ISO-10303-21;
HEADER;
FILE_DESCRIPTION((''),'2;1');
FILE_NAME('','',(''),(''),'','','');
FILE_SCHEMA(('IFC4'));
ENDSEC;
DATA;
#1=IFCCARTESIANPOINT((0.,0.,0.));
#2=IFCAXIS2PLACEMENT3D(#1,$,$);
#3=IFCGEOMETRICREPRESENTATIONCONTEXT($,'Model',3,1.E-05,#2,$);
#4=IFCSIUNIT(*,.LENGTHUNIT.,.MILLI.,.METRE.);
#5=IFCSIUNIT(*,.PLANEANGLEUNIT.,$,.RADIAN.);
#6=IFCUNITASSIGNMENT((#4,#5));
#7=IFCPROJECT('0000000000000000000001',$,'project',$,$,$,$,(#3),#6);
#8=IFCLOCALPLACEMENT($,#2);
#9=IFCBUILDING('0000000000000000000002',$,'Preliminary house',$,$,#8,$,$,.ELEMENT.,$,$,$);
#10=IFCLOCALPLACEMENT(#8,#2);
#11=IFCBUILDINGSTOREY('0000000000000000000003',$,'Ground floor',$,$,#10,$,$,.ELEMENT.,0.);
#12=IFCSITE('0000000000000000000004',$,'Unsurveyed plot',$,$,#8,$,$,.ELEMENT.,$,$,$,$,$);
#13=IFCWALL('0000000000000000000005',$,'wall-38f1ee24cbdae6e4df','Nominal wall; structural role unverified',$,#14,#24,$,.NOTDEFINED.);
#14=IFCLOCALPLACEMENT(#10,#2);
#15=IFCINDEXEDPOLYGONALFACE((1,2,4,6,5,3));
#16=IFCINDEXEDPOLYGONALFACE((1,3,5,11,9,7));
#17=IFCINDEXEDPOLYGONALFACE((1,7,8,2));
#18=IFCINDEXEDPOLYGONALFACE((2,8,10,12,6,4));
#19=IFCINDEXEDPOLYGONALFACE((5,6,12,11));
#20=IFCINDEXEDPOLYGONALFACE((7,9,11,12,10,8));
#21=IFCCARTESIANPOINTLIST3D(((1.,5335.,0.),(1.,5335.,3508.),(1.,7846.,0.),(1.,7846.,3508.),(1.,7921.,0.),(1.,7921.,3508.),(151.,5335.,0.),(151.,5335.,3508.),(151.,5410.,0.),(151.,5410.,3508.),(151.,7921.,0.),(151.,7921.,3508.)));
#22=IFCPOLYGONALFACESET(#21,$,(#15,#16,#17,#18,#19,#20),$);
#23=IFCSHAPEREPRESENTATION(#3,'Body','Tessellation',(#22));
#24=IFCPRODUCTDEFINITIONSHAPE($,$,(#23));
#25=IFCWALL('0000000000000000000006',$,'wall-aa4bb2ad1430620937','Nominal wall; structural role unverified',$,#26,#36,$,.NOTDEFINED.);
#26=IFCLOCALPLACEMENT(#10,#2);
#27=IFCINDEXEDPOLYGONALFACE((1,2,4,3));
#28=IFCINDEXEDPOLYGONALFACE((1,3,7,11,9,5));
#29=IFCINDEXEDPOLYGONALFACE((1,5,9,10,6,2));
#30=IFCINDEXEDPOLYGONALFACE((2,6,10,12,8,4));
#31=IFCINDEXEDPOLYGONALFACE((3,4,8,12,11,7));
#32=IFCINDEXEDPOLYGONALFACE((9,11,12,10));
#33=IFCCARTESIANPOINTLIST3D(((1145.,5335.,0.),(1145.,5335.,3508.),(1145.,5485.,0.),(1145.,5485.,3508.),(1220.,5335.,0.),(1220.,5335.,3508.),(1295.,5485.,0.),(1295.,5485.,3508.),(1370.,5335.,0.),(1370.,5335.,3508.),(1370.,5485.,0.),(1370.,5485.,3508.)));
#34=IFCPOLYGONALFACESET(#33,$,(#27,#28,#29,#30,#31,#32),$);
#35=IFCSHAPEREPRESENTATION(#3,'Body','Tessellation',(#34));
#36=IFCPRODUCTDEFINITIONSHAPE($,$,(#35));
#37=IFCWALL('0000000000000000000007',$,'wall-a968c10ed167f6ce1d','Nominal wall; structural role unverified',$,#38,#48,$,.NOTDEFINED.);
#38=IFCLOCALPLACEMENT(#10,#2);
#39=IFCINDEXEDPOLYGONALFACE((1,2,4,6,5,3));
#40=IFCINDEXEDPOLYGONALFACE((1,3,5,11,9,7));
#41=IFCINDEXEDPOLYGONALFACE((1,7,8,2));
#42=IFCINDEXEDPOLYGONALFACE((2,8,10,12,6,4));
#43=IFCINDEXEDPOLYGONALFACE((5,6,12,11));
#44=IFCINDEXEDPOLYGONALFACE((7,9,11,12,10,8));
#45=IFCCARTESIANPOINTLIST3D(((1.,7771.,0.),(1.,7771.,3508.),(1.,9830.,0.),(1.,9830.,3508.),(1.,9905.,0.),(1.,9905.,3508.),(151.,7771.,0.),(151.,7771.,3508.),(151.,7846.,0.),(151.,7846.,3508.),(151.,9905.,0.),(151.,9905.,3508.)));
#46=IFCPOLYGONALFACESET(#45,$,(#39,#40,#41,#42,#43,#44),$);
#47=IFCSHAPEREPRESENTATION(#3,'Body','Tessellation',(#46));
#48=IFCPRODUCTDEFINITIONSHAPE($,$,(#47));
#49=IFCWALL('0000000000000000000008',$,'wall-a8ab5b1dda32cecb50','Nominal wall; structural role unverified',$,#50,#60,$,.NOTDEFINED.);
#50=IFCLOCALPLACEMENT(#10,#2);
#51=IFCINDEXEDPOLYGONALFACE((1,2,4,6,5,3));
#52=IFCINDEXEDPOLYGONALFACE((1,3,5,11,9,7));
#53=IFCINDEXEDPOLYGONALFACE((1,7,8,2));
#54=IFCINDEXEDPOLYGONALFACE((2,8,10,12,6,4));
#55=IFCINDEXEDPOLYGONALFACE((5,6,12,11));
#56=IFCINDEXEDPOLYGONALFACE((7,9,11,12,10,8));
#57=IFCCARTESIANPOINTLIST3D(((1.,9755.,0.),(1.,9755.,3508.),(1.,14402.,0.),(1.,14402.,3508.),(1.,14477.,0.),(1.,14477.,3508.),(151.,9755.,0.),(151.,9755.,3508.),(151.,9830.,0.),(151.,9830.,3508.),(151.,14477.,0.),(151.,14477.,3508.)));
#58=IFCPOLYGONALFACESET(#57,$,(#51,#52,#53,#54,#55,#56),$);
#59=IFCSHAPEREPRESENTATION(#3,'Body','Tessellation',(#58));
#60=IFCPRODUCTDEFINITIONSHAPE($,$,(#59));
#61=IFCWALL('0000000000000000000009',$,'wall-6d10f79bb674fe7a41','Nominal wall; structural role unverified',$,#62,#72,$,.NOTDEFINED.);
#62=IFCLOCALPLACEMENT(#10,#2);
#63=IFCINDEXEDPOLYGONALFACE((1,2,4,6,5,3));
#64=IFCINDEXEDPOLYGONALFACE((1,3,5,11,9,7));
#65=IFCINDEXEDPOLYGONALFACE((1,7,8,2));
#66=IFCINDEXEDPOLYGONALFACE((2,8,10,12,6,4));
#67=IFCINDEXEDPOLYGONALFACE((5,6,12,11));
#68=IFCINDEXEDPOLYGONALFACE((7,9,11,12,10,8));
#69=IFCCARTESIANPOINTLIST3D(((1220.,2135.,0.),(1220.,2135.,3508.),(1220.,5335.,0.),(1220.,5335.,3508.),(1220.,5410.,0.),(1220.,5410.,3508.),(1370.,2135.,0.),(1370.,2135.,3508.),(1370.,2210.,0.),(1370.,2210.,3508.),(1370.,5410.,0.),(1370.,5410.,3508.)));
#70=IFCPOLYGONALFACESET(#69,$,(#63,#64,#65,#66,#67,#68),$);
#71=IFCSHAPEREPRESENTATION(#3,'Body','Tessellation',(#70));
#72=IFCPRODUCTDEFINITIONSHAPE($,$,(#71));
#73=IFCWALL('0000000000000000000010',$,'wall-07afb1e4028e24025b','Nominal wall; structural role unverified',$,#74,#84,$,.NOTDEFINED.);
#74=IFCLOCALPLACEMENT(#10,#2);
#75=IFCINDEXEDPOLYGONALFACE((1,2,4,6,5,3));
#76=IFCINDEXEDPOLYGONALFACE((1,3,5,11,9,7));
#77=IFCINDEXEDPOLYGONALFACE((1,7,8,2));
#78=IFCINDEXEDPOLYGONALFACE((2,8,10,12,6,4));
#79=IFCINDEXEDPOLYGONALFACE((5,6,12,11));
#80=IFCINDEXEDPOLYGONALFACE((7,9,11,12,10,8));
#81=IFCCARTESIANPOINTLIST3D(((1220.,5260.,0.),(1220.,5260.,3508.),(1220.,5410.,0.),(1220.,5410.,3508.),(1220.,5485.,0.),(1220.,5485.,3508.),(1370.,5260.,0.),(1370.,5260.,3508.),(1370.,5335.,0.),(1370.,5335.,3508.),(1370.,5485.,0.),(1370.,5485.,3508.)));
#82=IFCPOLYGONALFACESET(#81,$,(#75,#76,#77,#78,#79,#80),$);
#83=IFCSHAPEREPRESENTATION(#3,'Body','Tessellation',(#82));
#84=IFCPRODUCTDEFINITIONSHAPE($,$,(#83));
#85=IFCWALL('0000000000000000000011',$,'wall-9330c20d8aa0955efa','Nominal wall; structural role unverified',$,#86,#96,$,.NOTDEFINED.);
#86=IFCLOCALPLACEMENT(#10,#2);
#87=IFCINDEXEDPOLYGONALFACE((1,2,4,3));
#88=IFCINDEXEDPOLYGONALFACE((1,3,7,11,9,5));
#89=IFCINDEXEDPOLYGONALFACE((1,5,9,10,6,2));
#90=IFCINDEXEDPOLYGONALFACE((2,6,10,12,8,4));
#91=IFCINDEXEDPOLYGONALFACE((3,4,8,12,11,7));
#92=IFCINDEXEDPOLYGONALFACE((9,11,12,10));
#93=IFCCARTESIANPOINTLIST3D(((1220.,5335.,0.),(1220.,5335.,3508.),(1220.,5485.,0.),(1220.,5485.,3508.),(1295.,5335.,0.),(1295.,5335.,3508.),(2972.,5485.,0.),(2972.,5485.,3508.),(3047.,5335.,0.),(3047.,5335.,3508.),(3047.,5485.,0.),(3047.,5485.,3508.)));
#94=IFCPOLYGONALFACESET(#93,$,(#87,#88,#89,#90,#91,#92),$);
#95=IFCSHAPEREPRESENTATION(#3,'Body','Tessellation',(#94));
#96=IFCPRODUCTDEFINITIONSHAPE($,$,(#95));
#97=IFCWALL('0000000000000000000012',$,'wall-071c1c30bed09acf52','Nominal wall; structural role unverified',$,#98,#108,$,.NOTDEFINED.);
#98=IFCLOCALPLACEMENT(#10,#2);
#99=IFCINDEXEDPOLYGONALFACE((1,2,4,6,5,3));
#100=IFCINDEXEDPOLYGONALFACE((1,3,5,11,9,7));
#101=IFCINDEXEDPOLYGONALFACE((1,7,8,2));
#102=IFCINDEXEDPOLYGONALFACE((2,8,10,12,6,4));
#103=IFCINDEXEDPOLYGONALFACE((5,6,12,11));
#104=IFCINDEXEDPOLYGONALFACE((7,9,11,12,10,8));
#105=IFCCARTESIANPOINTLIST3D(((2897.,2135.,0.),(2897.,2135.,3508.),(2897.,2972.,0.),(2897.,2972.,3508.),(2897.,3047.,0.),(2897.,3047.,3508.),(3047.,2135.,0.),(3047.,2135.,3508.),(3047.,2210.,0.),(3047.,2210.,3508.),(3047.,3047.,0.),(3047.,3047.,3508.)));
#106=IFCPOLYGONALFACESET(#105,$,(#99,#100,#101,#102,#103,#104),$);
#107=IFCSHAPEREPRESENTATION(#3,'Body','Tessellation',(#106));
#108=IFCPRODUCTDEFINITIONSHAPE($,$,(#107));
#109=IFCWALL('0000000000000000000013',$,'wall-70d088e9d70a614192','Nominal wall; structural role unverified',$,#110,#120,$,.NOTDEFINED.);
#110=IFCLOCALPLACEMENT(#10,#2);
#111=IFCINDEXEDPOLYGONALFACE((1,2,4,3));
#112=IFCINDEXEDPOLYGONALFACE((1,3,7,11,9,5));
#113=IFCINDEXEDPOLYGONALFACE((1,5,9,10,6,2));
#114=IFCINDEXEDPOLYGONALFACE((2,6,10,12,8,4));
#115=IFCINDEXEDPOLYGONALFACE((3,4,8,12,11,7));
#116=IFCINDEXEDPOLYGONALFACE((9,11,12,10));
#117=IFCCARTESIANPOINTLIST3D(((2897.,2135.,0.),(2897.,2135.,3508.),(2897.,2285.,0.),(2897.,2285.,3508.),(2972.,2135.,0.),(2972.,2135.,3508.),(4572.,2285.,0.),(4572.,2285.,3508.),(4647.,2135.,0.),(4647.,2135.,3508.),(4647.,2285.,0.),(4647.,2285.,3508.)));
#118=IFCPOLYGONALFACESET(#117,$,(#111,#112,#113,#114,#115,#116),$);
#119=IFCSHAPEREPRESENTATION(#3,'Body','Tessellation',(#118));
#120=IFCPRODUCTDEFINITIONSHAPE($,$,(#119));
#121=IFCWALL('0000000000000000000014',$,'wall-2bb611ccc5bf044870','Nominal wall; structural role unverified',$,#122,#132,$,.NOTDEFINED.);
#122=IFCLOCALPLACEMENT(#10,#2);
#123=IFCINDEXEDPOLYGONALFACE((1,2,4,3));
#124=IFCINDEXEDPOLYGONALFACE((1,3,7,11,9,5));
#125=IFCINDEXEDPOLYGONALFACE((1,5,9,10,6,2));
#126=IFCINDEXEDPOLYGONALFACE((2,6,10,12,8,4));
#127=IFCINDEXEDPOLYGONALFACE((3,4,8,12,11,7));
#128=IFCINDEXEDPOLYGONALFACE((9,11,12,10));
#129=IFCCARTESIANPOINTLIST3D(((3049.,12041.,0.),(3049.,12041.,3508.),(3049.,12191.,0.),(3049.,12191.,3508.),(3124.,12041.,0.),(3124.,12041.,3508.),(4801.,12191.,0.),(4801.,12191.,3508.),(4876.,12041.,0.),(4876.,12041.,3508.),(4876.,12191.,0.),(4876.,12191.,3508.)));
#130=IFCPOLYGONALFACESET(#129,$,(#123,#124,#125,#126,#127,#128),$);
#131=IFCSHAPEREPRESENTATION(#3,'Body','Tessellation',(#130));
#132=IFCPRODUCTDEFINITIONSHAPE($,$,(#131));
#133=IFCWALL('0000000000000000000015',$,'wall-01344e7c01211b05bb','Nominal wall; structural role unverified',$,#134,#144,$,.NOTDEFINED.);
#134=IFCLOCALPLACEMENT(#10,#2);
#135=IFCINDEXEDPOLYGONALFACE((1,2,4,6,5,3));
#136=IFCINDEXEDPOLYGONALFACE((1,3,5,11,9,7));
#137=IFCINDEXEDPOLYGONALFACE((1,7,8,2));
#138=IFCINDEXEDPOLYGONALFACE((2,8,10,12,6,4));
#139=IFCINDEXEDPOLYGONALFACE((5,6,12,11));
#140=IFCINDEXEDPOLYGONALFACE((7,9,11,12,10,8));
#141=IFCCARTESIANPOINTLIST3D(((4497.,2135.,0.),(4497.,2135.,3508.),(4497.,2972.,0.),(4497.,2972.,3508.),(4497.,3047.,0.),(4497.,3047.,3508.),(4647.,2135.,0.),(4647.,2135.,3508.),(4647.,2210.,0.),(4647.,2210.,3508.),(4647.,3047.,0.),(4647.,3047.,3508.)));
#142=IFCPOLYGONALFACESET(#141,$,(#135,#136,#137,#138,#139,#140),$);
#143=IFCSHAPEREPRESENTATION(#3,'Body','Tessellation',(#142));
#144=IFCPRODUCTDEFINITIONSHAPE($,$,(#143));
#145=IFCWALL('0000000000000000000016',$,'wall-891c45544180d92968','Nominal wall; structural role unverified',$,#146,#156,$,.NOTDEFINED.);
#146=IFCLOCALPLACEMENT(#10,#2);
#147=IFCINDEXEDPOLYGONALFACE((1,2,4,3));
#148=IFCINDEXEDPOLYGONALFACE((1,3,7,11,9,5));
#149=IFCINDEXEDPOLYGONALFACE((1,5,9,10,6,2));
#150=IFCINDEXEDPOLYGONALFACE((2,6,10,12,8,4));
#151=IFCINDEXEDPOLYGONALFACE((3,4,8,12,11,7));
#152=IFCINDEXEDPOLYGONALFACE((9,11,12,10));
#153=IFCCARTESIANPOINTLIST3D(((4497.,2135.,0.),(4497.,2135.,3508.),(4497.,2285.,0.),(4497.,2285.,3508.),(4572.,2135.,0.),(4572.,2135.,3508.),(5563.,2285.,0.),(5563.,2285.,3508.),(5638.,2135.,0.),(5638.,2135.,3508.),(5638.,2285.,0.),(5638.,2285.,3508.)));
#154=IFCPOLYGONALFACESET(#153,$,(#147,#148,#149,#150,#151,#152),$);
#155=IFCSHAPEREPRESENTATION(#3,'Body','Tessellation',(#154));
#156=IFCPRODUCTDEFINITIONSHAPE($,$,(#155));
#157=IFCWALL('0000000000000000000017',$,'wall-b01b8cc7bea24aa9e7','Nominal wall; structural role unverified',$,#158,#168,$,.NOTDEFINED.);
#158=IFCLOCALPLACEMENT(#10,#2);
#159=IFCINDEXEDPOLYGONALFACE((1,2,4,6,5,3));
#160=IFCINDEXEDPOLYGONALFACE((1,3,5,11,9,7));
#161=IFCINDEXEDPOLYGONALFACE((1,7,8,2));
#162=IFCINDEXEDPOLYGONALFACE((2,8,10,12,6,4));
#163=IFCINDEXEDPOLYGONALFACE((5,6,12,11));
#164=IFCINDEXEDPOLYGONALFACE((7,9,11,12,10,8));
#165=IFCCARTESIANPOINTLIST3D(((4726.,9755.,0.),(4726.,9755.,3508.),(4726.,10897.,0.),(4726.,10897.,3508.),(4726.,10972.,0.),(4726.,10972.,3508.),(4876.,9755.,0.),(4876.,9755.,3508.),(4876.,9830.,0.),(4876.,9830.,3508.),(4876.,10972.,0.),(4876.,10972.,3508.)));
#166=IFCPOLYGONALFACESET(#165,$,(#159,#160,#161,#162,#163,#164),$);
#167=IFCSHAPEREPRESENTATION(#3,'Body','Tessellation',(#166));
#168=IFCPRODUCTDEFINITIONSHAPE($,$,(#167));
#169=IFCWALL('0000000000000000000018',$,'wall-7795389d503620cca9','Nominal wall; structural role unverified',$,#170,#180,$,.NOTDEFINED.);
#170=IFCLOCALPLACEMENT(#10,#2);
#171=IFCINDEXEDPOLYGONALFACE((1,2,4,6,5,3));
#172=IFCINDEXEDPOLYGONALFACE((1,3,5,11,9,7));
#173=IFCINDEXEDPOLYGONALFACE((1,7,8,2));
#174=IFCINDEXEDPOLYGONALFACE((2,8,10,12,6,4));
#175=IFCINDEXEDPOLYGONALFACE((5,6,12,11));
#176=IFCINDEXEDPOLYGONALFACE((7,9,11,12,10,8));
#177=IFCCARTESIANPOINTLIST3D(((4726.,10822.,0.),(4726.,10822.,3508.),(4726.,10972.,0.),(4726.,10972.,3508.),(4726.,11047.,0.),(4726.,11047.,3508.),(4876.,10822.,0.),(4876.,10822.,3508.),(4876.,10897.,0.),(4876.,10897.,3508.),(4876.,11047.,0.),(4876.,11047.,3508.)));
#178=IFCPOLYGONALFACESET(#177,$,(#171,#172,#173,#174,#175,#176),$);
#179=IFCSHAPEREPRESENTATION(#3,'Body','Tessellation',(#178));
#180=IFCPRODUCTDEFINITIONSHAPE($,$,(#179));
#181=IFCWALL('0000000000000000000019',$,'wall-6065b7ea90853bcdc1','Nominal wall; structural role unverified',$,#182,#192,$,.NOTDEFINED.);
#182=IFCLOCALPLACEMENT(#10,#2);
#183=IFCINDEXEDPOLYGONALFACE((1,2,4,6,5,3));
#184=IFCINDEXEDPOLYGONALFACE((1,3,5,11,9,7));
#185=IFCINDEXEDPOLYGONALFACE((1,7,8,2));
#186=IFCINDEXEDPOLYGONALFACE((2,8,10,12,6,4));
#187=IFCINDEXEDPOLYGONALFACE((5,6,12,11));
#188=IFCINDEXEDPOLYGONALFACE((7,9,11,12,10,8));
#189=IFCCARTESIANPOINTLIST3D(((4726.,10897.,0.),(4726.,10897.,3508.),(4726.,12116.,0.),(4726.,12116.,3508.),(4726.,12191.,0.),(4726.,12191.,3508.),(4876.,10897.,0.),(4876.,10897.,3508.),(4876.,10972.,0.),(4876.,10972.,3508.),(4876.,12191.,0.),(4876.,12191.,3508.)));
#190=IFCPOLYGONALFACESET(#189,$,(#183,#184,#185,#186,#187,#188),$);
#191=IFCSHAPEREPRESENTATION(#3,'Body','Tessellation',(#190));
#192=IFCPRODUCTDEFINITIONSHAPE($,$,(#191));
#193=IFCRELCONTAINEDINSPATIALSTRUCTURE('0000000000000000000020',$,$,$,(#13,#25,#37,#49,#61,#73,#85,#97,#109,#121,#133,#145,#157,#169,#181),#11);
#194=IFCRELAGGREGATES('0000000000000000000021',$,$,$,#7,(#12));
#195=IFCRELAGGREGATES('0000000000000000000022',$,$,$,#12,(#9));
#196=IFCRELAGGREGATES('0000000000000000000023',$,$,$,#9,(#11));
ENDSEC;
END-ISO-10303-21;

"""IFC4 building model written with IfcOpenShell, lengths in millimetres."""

from ifc_helpers import new_model, si_unit, origin, place, context, project, spatial, polyline, outline, extrude, element, save


model = new_model("IFC4")

# Units and contexts
model_context = context("Model", 3, precision=1e-05, world=origin())
ifc_project = project(units=[si_unit("LENGTHUNIT", "METRE", prefix="MILLI"), si_unit("PLANEANGLEUNIT", "RADIAN")], contexts=[model_context])

# Site, building, storey
placement_1 = place(None, origin())
site = spatial("IfcSite", under=ifc_project, at=placement_1, Name="Unsurveyed plot", CompositionType="ELEMENT")
building = spatial("IfcBuilding", under=site, at=placement_1, Name="Preliminary house", CompositionType="ELEMENT")
placement_2 = place(placement_1, origin())
storey = spatial("IfcBuildingStorey", under=building, at=placement_2, Name="Ground floor", CompositionType="ELEMENT", Elevation=0.0)

# Wall
element("IfcWall", 1, at=placement_2, inside=storey, Name="wall-38f1ee24cbdae6e4df", Description="Nominal wall; structural role unverified", PredefinedType="NOTDEFINED", context=model_context, shape_type="SweptSolid", body=[
    extrude(outline(polyline([(1.0, 7846.0), (1.0, 7921.0), (151.0, 7921.0), (151.0, 5410.0), (151.0, 5335.0), (1.0, 5335.0), (1.0, 7846.0)])), origin(), (0.0, 0.0, 1.0), 3508.0),
])

# Walls
element("IfcWall", 2, at=placement_2, inside=storey, Name="wall-aa4bb2ad1430620937", Description="Nominal wall; structural role unverified", PredefinedType="NOTDEFINED", context=model_context, shape_type="SweptSolid", body=[
    extrude(outline(polyline([(1295.0, 5485.0), (1370.0, 5485.0), (1370.0, 5335.0), (1220.0, 5335.0), (1145.0, 5335.0), (1145.0, 5485.0), (1295.0, 5485.0)])), origin(), (0.0, 0.0, 1.0), 3508.0),
])
element("IfcWall", 3, at=placement_2, inside=storey, Name="wall-a968c10ed167f6ce1d", Description="Nominal wall; structural role unverified", PredefinedType="NOTDEFINED", context=model_context, shape_type="SweptSolid", body=[
    extrude(outline(polyline([(1.0, 9830.0), (1.0, 9905.0), (151.0, 9905.0), (151.0, 7846.0), (151.0, 7771.0), (1.0, 7771.0), (1.0, 9830.0)])), origin(), (0.0, 0.0, 1.0), 3508.0),
])

# Wall
element("IfcWall", 4, at=placement_2, inside=storey, Name="wall-a8ab5b1dda32cecb50", Description="Nominal wall; structural role unverified", PredefinedType="NOTDEFINED", context=model_context, shape_type="SweptSolid", body=[
    extrude(outline(polyline([(1.0, 14402.0), (1.0, 14477.0), (151.0, 14477.0), (151.0, 9830.0), (151.0, 9755.0), (1.0, 9755.0), (1.0, 14402.0)])), origin(), (0.0, 0.0, 1.0), 3508.0),
])

# Walls
element("IfcWall", 5, at=placement_2, inside=storey, Name="wall-6d10f79bb674fe7a41", Description="Nominal wall; structural role unverified", PredefinedType="NOTDEFINED", context=model_context, shape_type="SweptSolid", body=[
    extrude(outline(polyline([(1220.0, 5335.0), (1220.0, 5410.0), (1370.0, 5410.0), (1370.0, 2210.0), (1370.0, 2135.0), (1220.0, 2135.0), (1220.0, 5335.0)])), origin(), (0.0, 0.0, 1.0), 3508.0),
])
element("IfcWall", 6, at=placement_2, inside=storey, Name="wall-07afb1e4028e24025b", Description="Nominal wall; structural role unverified", PredefinedType="NOTDEFINED", context=model_context, shape_type="SweptSolid", body=[
    extrude(outline(polyline([(1220.0, 5410.0), (1220.0, 5485.0), (1370.0, 5485.0), (1370.0, 5335.0), (1370.0, 5260.0), (1220.0, 5260.0), (1220.0, 5410.0)])), origin(), (0.0, 0.0, 1.0), 3508.0),
])

# Walls
element("IfcWall", 7, at=placement_2, inside=storey, Name="wall-9330c20d8aa0955efa", Description="Nominal wall; structural role unverified", PredefinedType="NOTDEFINED", context=model_context, shape_type="SweptSolid", body=[
    extrude(outline(polyline([(2972.0, 5485.0), (3047.0, 5485.0), (3047.0, 5335.0), (1295.0, 5335.0), (1220.0, 5335.0), (1220.0, 5485.0), (2972.0, 5485.0)])), origin(), (0.0, 0.0, 1.0), 3508.0),
])
element("IfcWall", 8, at=placement_2, inside=storey, Name="wall-071c1c30bed09acf52", Description="Nominal wall; structural role unverified", PredefinedType="NOTDEFINED", context=model_context, shape_type="SweptSolid", body=[
    extrude(outline(polyline([(2897.0, 2972.0), (2897.0, 3047.0), (3047.0, 3047.0), (3047.0, 2210.0), (3047.0, 2135.0), (2897.0, 2135.0), (2897.0, 2972.0)])), origin(), (0.0, 0.0, 1.0), 3508.0),
])
element("IfcWall", 9, at=placement_2, inside=storey, Name="wall-70d088e9d70a614192", Description="Nominal wall; structural role unverified", PredefinedType="NOTDEFINED", context=model_context, shape_type="SweptSolid", body=[
    extrude(outline(polyline([(4572.0, 2285.0), (4647.0, 2285.0), (4647.0, 2135.0), (2972.0, 2135.0), (2897.0, 2135.0), (2897.0, 2285.0), (4572.0, 2285.0)])), origin(), (0.0, 0.0, 1.0), 3508.0),
])

# Wall
element("IfcWall", 10, at=placement_2, inside=storey, Name="wall-2bb611ccc5bf044870", Description="Nominal wall; structural role unverified", PredefinedType="NOTDEFINED", context=model_context, shape_type="SweptSolid", body=[
    extrude(outline(polyline([(4801.0, 12191.0), (4876.0, 12191.0), (4876.0, 12041.0), (3124.0, 12041.0), (3049.0, 12041.0), (3049.0, 12191.0), (4801.0, 12191.0)])), origin(), (0.0, 0.0, 1.0), 3508.0),
])

# Walls
element("IfcWall", 11, at=placement_2, inside=storey, Name="wall-01344e7c01211b05bb", Description="Nominal wall; structural role unverified", PredefinedType="NOTDEFINED", context=model_context, shape_type="SweptSolid", body=[
    extrude(outline(polyline([(4497.0, 2972.0), (4497.0, 3047.0), (4647.0, 3047.0), (4647.0, 2210.0), (4647.0, 2135.0), (4497.0, 2135.0), (4497.0, 2972.0)])), origin(), (0.0, 0.0, 1.0), 3508.0),
])
element("IfcWall", 12, at=placement_2, inside=storey, Name="wall-891c45544180d92968", Description="Nominal wall; structural role unverified", PredefinedType="NOTDEFINED", context=model_context, shape_type="SweptSolid", body=[
    extrude(outline(polyline([(5563.0, 2285.0), (5638.0, 2285.0), (5638.0, 2135.0), (4572.0, 2135.0), (4497.0, 2135.0), (4497.0, 2285.0), (5563.0, 2285.0)])), origin(), (0.0, 0.0, 1.0), 3508.0),
])
element("IfcWall", 13, at=placement_2, inside=storey, Name="wall-b01b8cc7bea24aa9e7", Description="Nominal wall; structural role unverified", PredefinedType="NOTDEFINED", context=model_context, shape_type="SweptSolid", body=[
    extrude(outline(polyline([(4726.0, 10897.0), (4726.0, 10972.0), (4876.0, 10972.0), (4876.0, 9830.0), (4876.0, 9755.0), (4726.0, 9755.0), (4726.0, 10897.0)])), origin(), (0.0, 0.0, 1.0), 3508.0),
])

# Walls
element("IfcWall", 14, at=placement_2, inside=storey, Name="wall-7795389d503620cca9", Description="Nominal wall; structural role unverified", PredefinedType="NOTDEFINED", context=model_context, shape_type="SweptSolid", body=[
    extrude(outline(polyline([(4726.0, 10972.0), (4726.0, 11047.0), (4876.0, 11047.0), (4876.0, 10897.0), (4876.0, 10822.0), (4726.0, 10822.0), (4726.0, 10972.0)])), origin(), (0.0, 0.0, 1.0), 3508.0),
])
element("IfcWall", 15, at=placement_2, inside=storey, Name="wall-6065b7ea90853bcdc1", Description="Nominal wall; structural role unverified", PredefinedType="NOTDEFINED", context=model_context, shape_type="SweptSolid", body=[
    extrude(outline(polyline([(4726.0, 12116.0), (4726.0, 12191.0), (4876.0, 12191.0), (4876.0, 10972.0), (4876.0, 10897.0), (4726.0, 10897.0), (4726.0, 12116.0)])), origin(), (0.0, 0.0, 1.0), 3508.0),
])

save(model, "model.ifc")
